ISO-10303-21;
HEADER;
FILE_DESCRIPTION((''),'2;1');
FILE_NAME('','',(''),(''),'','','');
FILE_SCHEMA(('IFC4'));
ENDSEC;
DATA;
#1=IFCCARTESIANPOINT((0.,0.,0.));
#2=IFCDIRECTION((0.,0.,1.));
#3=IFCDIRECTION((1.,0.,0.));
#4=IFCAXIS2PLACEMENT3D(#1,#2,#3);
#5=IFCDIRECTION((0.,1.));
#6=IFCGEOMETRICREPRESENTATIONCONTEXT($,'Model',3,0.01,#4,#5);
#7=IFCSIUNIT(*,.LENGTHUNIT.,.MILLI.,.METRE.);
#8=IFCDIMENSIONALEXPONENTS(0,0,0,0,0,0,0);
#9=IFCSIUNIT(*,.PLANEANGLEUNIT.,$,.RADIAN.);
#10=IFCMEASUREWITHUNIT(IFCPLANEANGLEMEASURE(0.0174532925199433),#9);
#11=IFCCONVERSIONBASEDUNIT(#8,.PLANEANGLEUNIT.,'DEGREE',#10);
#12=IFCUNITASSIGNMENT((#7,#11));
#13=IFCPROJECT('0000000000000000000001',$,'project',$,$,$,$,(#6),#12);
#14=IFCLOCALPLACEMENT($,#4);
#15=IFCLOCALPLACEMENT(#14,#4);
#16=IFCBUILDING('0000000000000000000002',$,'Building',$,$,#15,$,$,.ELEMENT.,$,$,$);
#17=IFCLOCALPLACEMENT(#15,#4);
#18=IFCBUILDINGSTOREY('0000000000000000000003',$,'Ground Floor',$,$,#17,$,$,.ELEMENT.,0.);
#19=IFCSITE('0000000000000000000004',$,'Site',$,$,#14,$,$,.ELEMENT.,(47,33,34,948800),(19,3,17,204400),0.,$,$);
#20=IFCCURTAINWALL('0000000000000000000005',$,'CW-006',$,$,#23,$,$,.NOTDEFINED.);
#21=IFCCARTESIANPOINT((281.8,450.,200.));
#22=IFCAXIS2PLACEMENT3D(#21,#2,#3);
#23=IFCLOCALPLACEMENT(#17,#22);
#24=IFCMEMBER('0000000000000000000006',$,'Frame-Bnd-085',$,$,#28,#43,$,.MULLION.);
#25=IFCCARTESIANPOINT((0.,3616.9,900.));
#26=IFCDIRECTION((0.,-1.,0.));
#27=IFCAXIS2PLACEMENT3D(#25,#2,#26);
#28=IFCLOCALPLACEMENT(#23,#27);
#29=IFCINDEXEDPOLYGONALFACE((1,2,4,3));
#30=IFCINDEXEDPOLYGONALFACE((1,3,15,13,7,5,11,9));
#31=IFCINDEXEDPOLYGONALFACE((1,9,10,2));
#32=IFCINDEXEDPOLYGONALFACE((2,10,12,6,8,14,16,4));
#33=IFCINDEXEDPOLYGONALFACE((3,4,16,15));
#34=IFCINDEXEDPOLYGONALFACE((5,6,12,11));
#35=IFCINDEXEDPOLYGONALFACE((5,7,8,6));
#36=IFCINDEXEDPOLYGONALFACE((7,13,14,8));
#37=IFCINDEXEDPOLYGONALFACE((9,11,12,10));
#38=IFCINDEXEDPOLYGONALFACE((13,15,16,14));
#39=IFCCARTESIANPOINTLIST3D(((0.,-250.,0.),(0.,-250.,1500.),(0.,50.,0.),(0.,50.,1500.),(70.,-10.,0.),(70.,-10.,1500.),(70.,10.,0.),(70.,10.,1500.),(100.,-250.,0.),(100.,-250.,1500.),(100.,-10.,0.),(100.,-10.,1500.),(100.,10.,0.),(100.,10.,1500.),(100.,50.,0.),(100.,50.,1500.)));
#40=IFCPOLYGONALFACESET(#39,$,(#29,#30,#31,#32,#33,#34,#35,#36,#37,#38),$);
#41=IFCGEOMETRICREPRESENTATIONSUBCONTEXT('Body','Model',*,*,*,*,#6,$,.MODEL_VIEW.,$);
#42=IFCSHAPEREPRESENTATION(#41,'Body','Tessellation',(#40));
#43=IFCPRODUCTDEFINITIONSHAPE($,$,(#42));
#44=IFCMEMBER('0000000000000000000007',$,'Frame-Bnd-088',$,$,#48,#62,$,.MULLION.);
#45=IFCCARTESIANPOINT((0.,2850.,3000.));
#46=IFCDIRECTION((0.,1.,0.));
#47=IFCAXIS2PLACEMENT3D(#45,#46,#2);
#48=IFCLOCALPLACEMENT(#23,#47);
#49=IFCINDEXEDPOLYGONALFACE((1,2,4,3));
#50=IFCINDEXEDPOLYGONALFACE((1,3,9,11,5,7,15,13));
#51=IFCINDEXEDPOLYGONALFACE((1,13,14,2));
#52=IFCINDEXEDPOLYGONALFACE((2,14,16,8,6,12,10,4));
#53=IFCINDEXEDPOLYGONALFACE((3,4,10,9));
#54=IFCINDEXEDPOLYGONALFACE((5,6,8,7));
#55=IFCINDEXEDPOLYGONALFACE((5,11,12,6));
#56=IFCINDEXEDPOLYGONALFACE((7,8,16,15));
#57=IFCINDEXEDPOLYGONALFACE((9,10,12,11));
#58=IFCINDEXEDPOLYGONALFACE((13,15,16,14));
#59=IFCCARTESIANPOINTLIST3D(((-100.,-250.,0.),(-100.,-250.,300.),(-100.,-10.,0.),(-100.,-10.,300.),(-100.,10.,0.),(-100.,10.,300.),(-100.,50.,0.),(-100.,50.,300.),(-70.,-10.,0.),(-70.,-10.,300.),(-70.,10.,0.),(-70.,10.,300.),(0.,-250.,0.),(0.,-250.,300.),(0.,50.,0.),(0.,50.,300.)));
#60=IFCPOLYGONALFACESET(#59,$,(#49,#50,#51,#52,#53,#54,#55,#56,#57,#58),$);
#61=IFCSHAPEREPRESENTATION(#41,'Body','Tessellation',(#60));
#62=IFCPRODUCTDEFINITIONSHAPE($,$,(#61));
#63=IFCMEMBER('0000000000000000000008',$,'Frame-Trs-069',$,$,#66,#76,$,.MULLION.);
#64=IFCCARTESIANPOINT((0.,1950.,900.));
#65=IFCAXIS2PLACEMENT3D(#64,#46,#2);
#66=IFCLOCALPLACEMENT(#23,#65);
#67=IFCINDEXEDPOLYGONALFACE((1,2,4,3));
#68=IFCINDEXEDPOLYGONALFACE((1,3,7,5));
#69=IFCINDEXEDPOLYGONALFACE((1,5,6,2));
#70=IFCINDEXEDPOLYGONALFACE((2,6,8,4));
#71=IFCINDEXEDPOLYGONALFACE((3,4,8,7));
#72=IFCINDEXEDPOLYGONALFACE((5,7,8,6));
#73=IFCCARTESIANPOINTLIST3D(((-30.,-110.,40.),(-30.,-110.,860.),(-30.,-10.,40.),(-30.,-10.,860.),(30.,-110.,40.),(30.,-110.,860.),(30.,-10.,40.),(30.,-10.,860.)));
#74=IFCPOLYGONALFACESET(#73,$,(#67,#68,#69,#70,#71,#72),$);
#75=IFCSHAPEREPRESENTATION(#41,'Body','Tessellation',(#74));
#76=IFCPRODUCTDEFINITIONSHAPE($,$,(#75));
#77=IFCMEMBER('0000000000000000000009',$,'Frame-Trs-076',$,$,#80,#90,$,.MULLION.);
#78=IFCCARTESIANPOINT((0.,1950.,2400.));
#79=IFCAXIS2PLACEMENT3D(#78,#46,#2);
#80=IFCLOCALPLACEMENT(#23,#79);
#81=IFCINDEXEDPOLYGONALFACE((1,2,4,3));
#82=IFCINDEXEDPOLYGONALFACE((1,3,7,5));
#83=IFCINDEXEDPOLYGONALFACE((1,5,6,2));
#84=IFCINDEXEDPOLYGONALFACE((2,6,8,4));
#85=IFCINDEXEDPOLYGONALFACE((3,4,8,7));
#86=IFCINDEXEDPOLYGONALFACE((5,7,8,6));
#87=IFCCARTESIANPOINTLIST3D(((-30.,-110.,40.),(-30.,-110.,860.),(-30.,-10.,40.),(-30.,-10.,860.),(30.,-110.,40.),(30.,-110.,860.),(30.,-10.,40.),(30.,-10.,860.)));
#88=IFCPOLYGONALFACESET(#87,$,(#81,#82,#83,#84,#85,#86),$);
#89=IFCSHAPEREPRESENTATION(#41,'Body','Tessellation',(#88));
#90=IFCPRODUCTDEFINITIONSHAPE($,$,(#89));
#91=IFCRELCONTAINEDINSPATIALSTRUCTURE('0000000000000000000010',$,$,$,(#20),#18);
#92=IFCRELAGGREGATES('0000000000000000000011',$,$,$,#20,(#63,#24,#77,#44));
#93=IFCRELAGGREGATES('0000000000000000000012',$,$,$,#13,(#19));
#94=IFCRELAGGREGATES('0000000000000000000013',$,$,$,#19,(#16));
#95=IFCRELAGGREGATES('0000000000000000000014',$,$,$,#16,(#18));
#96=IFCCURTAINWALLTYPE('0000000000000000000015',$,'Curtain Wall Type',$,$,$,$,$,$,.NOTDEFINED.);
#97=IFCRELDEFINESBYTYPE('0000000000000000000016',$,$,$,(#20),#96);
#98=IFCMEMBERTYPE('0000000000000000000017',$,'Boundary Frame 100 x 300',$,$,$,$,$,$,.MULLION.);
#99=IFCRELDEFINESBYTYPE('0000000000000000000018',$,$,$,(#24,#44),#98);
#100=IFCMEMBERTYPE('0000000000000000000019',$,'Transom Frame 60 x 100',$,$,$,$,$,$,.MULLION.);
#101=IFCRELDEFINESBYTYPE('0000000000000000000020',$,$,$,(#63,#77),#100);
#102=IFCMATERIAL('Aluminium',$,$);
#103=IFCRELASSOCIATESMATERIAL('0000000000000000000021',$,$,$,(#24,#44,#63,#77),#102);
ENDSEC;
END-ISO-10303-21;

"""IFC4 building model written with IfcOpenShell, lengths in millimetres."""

from ifc_helpers import new_model, entity, si_unit, converted_unit, direction, frame, frame_2d, origin_with_axes, place, context, subcontext, project, spatial, line, indexed_curve, rectangle, outline, extrude, material, type_object, element, aggregate, save


model = new_model("IFC4")

# Units and contexts
model_context = context("Model", 3, precision=0.01, world=origin_with_axes(), true_north=direction((0.0, 1.0)))
body_context = subcontext(model_context, "Body", "Model", "MODEL_VIEW")
ifc_project = project(units=[si_unit("LENGTHUNIT", "METRE", prefix="MILLI"), converted_unit("PLANEANGLEUNIT", "DEGREE", entity("IfcPlaneAngleMeasure", 0.0174532925199433), si_unit("PLANEANGLEUNIT", "RADIAN"), dimensions=[0, 0, 0, 0, 0, 0, 0])], contexts=[model_context])

# Site, building, storey
site_placement = place(None, origin_with_axes())
site = spatial("IfcSite", under=ifc_project, at=site_placement, Name="Site", CompositionType="ELEMENT", RefLatitude=(47, 33, 34, 948800), RefLongitude=(19, 3, 17, 204400), RefElevation=0.0)
building_placement = place(site_placement, origin_with_axes())
building = spatial("IfcBuilding", under=site, at=building_placement, Name="Building", CompositionType="ELEMENT")
storey_placement = place(building_placement, origin_with_axes())
storey = spatial("IfcBuildingStorey", under=building, at=storey_placement, Name="Ground Floor", CompositionType="ELEMENT", Elevation=0.0)

# Curtain wall, members
curtain_wall_type = type_object("IfcCurtainWallType", Name="Curtain Wall Type", PredefinedType="NOTDEFINED")
curtain_wall_placement = place(storey_placement, frame((281.8, 450.0, 200.0), z_axis=(0.0, 0.0, 1.0), x_axis=(1.0, 0.0, 0.0)))
curtain_wall = element("IfcCurtainWall", 1, at=curtain_wall_placement, inside=storey, type_object=curtain_wall_type, Name="CW-006", PredefinedType="NOTDEFINED")
ifc_material_1 = material(Name="Aluminium")
member_type_1 = type_object("IfcMemberType", Name="Boundary Frame 100 x 300", PredefinedType="MULLION")
member_1_placement = place(curtain_wall_placement, frame((0.0, 3616.9, 900.0), z_axis=(0.0, 0.0, 1.0), x_axis=(0.0, -1.0, 0.0)))
member_1 = element("IfcMember", 2, at=member_1_placement, type_object=member_type_1, material=ifc_material_1, Name="Frame-Bnd-085", PredefinedType="MULLION", context=body_context, shape_type="SweptSolid", body=[
    extrude(outline(indexed_curve([(70.0, -10.0), (70.0, 10.0), (100.0, 10.0), (100.0, 50.0), (0.0, 50.0), (0.0, -250.0), (100.0, -250.0), (100.0, -10.0)], segments=[line(1, 2, 3, 4, 5, 6, 7, 8, 1)])), origin_with_axes(), (0.0, 0.0, 1.0), 1500.0),
])
member_2_placement = place(curtain_wall_placement, frame((0.0, 2850.0, 3000.0), z_axis=(0.0, 1.0, 0.0), x_axis=(0.0, 0.0, 1.0)))
member_2 = element("IfcMember", 3, at=member_2_placement, type_object=member_type_1, material=ifc_material_1, Name="Frame-Bnd-088", PredefinedType="MULLION", context=body_context, shape_type="SweptSolid", body=[
    extrude(outline(indexed_curve([(-70.0, -10.0), (-100.0, -10.0), (-100.0, -250.0), (0.0, -250.0), (0.0, 50.0), (-100.0, 50.0), (-100.0, 10.0), (-70.0, 10.0)], segments=[line(1, 2, 3, 4, 5, 6, 7, 8, 1)])), origin_with_axes(), (0.0, 0.0, 1.0), 300.0),
])
member_type_2 = type_object("IfcMemberType", Name="Transom Frame 60 x 100", PredefinedType="MULLION")
member_3_placement = place(curtain_wall_placement, frame((0.0, 1950.0, 900.0), z_axis=(0.0, 1.0, 0.0), x_axis=(0.0, 0.0, 1.0)))
member_3 = element("IfcMember", 4, at=member_3_placement, type_object=member_type_2, material=ifc_material_1, Name="Frame-Trs-069", PredefinedType="MULLION", context=body_context, shape_type="SweptSolid", body=[
    extrude(rectangle(XDim=100.0, YDim=60.0, at=frame_2d((0.0, -60.0), x_axis=(0.0, 1.0))), frame((0.0, 0.0, 40.0), z_axis=(0.0, 0.0, 1.0), x_axis=(1.0, 0.0, 0.0)), (0.0, 0.0, 1.0), 820.0),
])
member_4_placement = place(curtain_wall_placement, frame((0.0, 1950.0, 2400.0), z_axis=(0.0, 1.0, 0.0), x_axis=(0.0, 0.0, 1.0)))
member_4 = element("IfcMember", 5, at=member_4_placement, type_object=member_type_2, material=ifc_material_1, Name="Frame-Trs-076", PredefinedType="MULLION", context=body_context, shape_type="SweptSolid", body=[
    extrude(rectangle(XDim=100.0, YDim=60.0, at=frame_2d((0.0, -60.0), x_axis=(0.0, 1.0))), frame((0.0, 0.0, 40.0), z_axis=(0.0, 0.0, 1.0), x_axis=(1.0, 0.0, 0.0)), (0.0, 0.0, 1.0), 820.0),
])
aggregate(curtain_wall, [member_3, member_1, member_4, member_2])

save(model, "model.ifc")
